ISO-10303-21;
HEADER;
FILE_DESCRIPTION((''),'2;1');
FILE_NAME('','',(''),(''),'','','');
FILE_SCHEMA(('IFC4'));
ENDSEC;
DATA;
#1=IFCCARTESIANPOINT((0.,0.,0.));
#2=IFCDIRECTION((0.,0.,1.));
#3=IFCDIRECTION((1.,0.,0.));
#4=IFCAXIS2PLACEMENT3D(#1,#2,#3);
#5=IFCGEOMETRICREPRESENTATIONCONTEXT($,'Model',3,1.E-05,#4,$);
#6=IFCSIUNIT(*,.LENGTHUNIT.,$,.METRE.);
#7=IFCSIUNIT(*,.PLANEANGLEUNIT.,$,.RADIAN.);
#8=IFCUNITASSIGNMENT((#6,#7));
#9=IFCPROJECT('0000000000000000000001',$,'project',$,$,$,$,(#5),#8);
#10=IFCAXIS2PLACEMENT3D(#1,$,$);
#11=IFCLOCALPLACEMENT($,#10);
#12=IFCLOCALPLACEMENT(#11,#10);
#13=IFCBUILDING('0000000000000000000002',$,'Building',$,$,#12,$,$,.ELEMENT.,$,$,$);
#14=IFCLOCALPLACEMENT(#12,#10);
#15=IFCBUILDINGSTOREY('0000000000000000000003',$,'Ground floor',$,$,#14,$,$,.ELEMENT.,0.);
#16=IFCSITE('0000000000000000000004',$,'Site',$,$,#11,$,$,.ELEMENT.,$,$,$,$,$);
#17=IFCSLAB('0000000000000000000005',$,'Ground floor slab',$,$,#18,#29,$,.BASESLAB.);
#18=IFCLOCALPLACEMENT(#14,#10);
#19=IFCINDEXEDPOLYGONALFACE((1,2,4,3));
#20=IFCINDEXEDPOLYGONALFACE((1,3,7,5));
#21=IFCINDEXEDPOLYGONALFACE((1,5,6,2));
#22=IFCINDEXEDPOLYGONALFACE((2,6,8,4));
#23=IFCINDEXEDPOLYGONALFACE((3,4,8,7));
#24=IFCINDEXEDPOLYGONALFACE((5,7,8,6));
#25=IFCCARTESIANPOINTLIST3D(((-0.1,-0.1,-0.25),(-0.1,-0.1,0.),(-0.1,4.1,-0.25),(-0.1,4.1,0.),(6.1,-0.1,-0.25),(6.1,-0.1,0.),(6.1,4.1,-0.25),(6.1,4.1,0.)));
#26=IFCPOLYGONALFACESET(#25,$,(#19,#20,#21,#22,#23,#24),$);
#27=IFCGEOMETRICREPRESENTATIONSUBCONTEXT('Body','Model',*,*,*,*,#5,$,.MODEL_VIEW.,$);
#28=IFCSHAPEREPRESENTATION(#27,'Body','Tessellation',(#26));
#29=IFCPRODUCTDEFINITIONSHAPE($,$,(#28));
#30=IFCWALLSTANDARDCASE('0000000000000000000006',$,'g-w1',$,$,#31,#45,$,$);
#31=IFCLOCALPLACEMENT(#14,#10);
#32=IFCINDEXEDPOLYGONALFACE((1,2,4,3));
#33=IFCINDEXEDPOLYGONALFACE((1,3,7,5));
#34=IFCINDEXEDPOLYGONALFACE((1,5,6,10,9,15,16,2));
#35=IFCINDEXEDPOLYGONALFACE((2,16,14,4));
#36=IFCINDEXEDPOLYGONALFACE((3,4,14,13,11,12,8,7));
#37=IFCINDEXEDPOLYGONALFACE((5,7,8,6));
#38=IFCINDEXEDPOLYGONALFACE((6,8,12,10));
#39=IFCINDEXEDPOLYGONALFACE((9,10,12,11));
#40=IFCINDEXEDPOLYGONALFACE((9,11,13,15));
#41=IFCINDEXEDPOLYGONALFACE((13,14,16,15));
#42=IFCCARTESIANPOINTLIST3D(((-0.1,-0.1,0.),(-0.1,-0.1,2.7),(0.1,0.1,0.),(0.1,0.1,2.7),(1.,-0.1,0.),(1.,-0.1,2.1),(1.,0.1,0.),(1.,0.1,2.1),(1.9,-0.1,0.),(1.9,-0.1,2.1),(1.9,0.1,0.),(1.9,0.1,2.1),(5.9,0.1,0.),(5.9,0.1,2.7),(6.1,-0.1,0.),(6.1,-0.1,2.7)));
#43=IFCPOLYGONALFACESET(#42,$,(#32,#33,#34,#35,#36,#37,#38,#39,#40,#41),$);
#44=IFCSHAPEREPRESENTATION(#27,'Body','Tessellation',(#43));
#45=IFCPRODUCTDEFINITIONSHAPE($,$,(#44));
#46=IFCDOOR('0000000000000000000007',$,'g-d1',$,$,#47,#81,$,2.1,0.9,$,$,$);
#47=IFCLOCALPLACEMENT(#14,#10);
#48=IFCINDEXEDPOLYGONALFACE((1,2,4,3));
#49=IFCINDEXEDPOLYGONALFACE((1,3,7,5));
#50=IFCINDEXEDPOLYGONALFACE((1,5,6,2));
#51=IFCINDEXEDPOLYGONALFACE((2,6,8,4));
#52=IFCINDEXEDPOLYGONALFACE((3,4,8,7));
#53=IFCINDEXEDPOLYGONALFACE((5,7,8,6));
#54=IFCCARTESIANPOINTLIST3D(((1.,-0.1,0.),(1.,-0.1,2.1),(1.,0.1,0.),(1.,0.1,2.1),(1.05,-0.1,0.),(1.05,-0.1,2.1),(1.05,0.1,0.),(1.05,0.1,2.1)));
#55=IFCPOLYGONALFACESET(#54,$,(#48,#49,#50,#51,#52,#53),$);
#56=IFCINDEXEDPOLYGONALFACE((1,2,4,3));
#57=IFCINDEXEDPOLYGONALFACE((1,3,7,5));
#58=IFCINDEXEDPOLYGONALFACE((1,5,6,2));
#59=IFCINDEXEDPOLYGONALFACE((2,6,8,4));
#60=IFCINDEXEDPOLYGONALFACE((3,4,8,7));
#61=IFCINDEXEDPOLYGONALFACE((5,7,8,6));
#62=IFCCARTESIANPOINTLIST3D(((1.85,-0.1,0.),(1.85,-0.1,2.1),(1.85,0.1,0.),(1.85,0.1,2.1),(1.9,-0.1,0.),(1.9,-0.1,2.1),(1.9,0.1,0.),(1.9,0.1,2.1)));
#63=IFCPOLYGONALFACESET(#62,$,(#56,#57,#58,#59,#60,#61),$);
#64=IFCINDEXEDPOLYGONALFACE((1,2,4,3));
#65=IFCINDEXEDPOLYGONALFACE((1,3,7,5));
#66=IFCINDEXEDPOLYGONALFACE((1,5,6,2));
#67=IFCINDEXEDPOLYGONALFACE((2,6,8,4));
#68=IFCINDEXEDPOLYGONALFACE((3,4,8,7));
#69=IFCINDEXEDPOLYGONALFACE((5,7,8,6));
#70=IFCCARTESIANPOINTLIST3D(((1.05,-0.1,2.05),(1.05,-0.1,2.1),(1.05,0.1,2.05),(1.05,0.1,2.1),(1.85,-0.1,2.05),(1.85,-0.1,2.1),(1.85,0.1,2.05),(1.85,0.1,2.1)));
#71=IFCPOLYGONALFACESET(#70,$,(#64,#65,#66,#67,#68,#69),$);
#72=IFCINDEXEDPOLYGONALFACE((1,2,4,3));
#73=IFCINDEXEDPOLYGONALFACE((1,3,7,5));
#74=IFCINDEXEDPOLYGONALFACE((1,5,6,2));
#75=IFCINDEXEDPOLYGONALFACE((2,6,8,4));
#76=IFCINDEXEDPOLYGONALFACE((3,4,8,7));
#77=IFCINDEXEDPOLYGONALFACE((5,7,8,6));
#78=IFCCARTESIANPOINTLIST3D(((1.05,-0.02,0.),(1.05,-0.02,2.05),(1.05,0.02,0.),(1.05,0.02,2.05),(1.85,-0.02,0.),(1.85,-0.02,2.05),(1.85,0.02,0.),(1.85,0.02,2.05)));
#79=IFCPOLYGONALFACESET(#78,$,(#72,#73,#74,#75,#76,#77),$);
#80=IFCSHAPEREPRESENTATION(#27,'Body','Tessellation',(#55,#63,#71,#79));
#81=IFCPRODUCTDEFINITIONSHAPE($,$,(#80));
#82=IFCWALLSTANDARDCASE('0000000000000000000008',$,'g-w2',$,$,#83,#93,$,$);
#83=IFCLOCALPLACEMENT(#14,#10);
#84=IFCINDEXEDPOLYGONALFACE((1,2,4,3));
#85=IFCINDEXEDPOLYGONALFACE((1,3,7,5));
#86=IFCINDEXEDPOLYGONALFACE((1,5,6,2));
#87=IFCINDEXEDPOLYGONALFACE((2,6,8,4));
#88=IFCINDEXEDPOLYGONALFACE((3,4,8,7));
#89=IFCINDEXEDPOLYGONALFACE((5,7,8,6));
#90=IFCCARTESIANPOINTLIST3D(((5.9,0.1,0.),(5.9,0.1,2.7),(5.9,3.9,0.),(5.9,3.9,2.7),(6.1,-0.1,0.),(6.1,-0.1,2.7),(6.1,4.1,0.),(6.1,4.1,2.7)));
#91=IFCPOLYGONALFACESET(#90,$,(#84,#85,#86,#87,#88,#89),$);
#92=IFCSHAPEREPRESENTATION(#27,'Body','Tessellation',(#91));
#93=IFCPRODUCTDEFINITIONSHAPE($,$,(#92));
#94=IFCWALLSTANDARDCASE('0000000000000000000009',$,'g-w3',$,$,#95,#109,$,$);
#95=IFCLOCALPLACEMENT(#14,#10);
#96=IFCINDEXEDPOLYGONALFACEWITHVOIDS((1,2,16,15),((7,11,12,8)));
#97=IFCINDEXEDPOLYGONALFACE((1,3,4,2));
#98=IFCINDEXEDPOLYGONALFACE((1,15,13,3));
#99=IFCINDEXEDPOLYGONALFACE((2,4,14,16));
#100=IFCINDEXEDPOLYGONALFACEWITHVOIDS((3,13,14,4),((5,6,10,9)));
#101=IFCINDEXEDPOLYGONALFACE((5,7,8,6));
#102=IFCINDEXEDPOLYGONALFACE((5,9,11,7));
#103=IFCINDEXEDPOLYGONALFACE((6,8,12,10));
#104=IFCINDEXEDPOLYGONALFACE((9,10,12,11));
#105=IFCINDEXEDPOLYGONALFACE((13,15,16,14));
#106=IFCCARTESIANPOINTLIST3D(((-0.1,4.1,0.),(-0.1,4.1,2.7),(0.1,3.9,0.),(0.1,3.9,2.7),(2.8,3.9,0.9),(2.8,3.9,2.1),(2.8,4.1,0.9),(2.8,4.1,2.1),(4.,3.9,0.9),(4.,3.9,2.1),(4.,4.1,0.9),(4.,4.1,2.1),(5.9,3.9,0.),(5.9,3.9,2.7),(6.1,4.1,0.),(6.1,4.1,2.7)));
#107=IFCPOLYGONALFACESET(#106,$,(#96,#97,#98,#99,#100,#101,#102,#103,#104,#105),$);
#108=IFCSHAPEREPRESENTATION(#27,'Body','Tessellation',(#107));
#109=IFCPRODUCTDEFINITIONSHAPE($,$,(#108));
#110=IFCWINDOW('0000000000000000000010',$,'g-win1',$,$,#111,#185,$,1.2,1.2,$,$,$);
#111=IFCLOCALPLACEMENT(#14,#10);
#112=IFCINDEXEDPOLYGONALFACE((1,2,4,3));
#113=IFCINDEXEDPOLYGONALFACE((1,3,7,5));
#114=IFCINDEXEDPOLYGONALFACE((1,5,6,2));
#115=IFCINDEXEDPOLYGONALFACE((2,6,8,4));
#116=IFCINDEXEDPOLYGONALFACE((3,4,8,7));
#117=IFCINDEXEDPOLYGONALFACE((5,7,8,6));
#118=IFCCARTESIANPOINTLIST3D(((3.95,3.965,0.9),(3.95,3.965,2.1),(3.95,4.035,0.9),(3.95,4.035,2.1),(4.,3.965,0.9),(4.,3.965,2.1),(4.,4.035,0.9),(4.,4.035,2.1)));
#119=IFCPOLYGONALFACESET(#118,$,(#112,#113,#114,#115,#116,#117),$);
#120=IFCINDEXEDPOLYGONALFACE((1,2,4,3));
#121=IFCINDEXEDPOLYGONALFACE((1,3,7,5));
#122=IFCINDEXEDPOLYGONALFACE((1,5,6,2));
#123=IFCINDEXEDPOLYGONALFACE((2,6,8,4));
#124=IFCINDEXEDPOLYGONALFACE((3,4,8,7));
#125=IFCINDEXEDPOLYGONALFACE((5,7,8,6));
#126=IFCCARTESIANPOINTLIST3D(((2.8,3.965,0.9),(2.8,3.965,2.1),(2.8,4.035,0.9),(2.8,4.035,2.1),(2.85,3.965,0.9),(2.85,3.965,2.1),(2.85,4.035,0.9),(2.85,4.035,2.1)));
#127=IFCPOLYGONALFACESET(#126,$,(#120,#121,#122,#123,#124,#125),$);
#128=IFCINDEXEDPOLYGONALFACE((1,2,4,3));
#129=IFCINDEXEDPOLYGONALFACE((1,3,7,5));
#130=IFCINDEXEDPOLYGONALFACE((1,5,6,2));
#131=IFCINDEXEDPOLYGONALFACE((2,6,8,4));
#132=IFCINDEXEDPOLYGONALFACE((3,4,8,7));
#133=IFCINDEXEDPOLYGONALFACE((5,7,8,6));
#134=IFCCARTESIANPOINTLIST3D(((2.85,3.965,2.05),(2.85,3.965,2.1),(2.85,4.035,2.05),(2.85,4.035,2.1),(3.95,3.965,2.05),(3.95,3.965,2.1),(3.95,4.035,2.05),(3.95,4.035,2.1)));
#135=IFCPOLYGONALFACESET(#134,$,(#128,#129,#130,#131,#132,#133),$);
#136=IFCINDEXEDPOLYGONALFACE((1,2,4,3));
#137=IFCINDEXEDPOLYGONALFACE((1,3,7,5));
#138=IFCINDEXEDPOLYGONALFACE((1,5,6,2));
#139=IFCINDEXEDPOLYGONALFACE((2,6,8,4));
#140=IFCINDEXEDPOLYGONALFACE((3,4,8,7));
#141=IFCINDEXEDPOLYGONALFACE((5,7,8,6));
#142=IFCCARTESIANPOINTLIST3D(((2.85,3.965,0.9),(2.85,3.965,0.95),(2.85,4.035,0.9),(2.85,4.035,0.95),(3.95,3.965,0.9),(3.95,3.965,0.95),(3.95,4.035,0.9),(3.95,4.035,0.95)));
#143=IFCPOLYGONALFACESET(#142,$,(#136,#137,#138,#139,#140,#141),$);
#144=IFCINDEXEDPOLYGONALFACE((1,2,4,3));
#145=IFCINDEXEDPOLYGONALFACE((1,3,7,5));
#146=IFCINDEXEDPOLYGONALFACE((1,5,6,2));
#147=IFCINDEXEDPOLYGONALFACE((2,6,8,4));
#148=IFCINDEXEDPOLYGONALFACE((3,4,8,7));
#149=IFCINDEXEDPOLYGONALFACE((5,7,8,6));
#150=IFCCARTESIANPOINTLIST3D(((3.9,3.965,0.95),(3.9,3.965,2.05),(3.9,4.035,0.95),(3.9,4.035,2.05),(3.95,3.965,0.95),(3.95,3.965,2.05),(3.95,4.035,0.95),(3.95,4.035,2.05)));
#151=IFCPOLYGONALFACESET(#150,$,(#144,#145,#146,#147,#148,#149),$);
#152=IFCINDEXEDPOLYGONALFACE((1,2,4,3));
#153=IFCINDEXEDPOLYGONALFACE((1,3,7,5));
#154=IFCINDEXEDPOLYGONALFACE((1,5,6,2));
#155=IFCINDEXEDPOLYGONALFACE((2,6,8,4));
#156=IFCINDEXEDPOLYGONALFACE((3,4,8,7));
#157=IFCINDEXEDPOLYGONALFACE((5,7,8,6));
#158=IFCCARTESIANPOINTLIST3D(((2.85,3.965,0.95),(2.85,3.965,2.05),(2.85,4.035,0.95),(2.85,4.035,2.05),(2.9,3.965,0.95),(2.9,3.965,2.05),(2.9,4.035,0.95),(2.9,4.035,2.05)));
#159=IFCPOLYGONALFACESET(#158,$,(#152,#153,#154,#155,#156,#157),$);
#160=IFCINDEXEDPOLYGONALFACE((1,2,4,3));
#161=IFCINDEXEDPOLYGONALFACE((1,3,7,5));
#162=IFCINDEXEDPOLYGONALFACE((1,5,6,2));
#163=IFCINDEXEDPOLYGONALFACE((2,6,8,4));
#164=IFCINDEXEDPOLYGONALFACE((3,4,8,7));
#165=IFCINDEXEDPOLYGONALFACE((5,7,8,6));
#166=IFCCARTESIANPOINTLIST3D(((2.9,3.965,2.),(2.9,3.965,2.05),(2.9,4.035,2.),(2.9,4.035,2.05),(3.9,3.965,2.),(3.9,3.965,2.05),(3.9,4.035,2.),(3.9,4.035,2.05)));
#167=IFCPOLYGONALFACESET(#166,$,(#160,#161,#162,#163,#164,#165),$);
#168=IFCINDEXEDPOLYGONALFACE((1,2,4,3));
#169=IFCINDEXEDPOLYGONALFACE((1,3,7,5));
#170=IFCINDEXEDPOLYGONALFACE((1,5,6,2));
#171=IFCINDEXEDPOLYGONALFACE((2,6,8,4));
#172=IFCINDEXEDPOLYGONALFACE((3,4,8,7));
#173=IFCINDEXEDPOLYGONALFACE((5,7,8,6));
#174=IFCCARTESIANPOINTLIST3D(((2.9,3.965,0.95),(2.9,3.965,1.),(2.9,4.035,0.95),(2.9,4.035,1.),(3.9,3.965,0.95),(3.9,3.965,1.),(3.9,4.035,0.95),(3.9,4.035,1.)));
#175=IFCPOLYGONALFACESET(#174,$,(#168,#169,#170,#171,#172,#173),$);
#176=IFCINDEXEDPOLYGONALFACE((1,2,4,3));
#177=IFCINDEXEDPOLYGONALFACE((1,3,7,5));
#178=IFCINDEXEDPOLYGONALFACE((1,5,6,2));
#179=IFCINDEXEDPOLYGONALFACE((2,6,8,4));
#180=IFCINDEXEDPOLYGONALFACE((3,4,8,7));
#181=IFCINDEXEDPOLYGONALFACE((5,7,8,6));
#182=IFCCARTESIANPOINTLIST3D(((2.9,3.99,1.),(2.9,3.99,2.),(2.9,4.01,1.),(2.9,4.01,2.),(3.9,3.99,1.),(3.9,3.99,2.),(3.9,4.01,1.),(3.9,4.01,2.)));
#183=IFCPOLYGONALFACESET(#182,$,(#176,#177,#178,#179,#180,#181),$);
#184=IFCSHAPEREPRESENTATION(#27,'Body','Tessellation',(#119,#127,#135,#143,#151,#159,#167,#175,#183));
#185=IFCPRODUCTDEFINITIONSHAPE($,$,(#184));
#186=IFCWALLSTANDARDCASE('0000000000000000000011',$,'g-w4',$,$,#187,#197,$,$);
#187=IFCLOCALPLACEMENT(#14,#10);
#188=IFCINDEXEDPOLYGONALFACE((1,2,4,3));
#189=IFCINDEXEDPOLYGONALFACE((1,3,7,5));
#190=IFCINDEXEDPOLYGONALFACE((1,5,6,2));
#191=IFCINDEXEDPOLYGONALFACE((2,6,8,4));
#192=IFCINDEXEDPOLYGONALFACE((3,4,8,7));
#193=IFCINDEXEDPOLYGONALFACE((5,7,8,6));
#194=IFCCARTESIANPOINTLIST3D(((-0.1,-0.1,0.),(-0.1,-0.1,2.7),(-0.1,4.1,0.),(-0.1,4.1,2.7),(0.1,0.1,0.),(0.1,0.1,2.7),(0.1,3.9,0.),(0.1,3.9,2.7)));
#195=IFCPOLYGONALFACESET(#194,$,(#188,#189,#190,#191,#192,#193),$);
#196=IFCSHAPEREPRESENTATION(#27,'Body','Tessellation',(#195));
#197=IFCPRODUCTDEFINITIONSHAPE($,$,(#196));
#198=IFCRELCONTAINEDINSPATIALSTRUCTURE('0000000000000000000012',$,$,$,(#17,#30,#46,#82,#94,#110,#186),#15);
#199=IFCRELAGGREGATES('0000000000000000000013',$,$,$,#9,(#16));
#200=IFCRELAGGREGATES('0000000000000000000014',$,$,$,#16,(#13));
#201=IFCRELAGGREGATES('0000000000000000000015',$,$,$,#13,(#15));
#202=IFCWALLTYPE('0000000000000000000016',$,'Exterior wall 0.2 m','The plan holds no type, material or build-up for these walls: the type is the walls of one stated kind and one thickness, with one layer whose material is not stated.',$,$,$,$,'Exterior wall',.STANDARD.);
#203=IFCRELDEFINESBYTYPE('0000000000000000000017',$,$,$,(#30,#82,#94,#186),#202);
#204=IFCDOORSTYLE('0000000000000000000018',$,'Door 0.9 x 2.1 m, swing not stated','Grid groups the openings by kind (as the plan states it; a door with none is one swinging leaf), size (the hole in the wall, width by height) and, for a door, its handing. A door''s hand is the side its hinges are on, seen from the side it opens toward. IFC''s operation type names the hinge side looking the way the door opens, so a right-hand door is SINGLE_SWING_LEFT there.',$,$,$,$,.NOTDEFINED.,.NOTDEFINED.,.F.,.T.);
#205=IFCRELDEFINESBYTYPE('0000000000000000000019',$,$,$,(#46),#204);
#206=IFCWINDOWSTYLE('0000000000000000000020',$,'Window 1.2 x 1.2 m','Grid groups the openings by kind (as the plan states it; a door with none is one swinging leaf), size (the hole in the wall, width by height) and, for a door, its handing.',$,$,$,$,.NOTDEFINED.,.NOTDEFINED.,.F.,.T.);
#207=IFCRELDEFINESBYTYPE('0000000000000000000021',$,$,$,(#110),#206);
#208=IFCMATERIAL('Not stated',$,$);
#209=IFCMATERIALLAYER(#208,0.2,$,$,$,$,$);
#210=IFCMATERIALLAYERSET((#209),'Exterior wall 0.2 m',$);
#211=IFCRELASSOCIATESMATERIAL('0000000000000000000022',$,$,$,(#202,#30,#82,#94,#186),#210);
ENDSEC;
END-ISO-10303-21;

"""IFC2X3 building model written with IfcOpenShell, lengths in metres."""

from ifc_helpers import new_model, si_unit, frame, frame_2d, origin, origin_with_axes, place, context, subcontext, project, spatial, polyline, rectangle, outline, extrude, material, layer, layer_set, layer_usage, type_object, element, fill, save


model = new_model("IFC2X3")

# Units and contexts
model_context = context("Model", 3, precision=1e-05, world=origin_with_axes())
body_context = subcontext(model_context, "Body", "Model", "MODEL_VIEW")
ifc_project = project(units=[si_unit("LENGTHUNIT", "METRE"), si_unit("PLANEANGLEUNIT", "RADIAN")], contexts=[model_context])

# Site, building, storey
site_placement = place(None, origin())
site = spatial("IfcSite", under=ifc_project, at=site_placement, Name="Site", CompositionType="ELEMENT")
building_placement = place(site_placement, origin())
building = spatial("IfcBuilding", under=site, at=building_placement, Name="Building", CompositionType="ELEMENT")
storey_placement = place(building_placement, origin())
storey = spatial("IfcBuildingStorey", under=building, at=storey_placement, Name="Ground floor", CompositionType="ELEMENT", Elevation=0.0)

# Slab
slab_placement = place(storey_placement, frame((0.0, 0.0, -0.25)))
element("IfcSlab", 1, at=slab_placement, inside=storey, Name="Ground floor slab", PredefinedType="BASESLAB", context=body_context, shape_type="SweptSolid", body=[
    extrude(outline(polyline([(-0.1, -0.1), (6.1, -0.1), (6.1, 4.1), (-0.1, 4.1), (-0.1, -0.1)])), origin(), (0.0, 0.0, 1.0), 0.25),
])

# Wall, opening, door
ifc_material = material(Name="Not stated")
ifc_layer = layer(ifc_material, 0.2)
ifc_layer_set = layer_set([ifc_layer], Name="Exterior wall 0.2 m")
ifc_layer_usage = layer_usage(ifc_layer_set, "AXIS2", "POSITIVE", -0.1)
wall_type = type_object("IfcWallType", Name="Exterior wall 0.2 m", Description="The plan holds no type, material or build-up for these walls: the type is the walls of one stated kind and one thickness, with one layer whose material is not stated.", ElementType="Exterior wall", PredefinedType="STANDARD", material=ifc_layer_set)
wall_1_placement = place(storey_placement, origin_with_axes())
wall_1 = element("IfcWallStandardCase", 2, at=wall_1_placement, inside=storey, type_object=wall_type, material=ifc_layer_usage, Name="g-w1", context=body_context, shape_type="SweptSolid", body=[
    extrude(outline(polyline([(-0.1, -0.1), (6.1, -0.1), (5.9, 0.1), (0.1, 0.1), (-0.1, -0.1)])), origin(), (0.0, 0.0, 1.0), 2.7),
])
opening_1_placement = place(wall_1_placement, frame((1.0, 0.0, 0.0)))
opening_1 = element("IfcOpeningElement", 3, at=opening_1_placement, cuts=wall_1, context=body_context, shape_type="SweptSolid", body=[
    extrude(rectangle(XDim=0.9, YDim=0.22, at=frame_2d((0.45, 0.0), x_axis=(1.0, 0.0))), origin(), (0.0, 0.0, 1.0), 2.1),
])
door_style = type_object("IfcDoorStyle", Name="Door 0.9 x 2.1 m, swing not stated", Description="Grid groups the openings by kind (as the plan states it; a door with none is one swinging leaf), size (the hole in the wall, width by height) and, for a door, its handing. A door's hand is the side its hinges are on, seen from the side it opens toward. IFC's operation type names the hinge side looking the way the door opens, so a right-hand door is SINGLE_SWING_LEFT there.", ConstructionType="NOTDEFINED", OperationType="NOTDEFINED", ParameterTakesPrecedence=False, Sizeable=True)
door_placement = place(opening_1_placement, origin())
door = element("IfcDoor", 4, at=door_placement, inside=storey, type_object=door_style, Name="g-d1", OverallHeight=2.1, OverallWidth=0.9, context=body_context, shape_type="SweptSolid", body=[
    extrude(rectangle(XDim=0.05, YDim=0.2, at=frame_2d((0.025, 0.0), x_axis=(1.0, 0.0))), origin(), (0.0, 0.0, 1.0), 2.1),
    extrude(rectangle(XDim=0.05, YDim=0.2, at=frame_2d((0.875, 0.0), x_axis=(1.0, 0.0))), origin(), (0.0, 0.0, 1.0), 2.1),
    extrude(rectangle(XDim=0.8, YDim=0.2, at=frame_2d((0.45, 0.0), x_axis=(1.0, 0.0))), frame((0.0, 0.0, 2.05)), (0.0, 0.0, 1.0), 0.05),
    extrude(rectangle(XDim=0.8, YDim=0.04, at=frame_2d((0.45, 0.0), x_axis=(1.0, 0.0))), origin(), (0.0, 0.0, 1.0), 2.05),
])
fill(opening_1, door)

# Wall
wall_2_placement = place(storey_placement, frame((6.0, 0.0, 0.0), z_axis=(0.0, 0.0, 1.0), x_axis=(0.0, 1.0, 0.0)))
element("IfcWallStandardCase", 5, at=wall_2_placement, inside=storey, type_object=wall_type, material=ifc_layer_usage, Name="g-w2", context=body_context, shape_type="SweptSolid", body=[
    extrude(outline(polyline([(-0.1, -0.1), (4.1, -0.1), (3.9, 0.1), (0.1, 0.1), (-0.1, -0.1)])), origin(), (0.0, 0.0, 1.0), 2.7),
])

# Wall, opening, window
wall_3_placement = place(storey_placement, frame((6.0, 4.0, 0.0), z_axis=(0.0, 0.0, 1.0), x_axis=(-1.0, 0.0, 0.0)))
wall_3 = element("IfcWallStandardCase", 6, at=wall_3_placement, inside=storey, type_object=wall_type, material=ifc_layer_usage, Name="g-w3", context=body_context, shape_type="SweptSolid", body=[
    extrude(outline(polyline([(-0.1, -0.1), (6.1, -0.1), (5.9, 0.1), (0.1, 0.1), (-0.1, -0.1)])), origin(), (0.0, 0.0, 1.0), 2.7),
])
opening_2_placement = place(wall_3_placement, frame((2.0, 0.0, 0.9)))
opening_2 = element("IfcOpeningElement", 7, at=opening_2_placement, cuts=wall_3, context=body_context, shape_type="SweptSolid", body=[
    extrude(rectangle(XDim=1.2, YDim=0.22, at=frame_2d((0.6, 0.0), x_axis=(1.0, 0.0))), origin(), (0.0, 0.0, 1.0), 1.2),
])
window_style = type_object("IfcWindowStyle", Name="Window 1.2 x 1.2 m", Description="Grid groups the openings by kind (as the plan states it; a door with none is one swinging leaf), size (the hole in the wall, width by height) and, for a door, its handing.", ConstructionType="NOTDEFINED", OperationType="NOTDEFINED", ParameterTakesPrecedence=False, Sizeable=True)
window_placement = place(opening_2_placement, origin())
window = element("IfcWindow", 8, at=window_placement, inside=storey, type_object=window_style, Name="g-win1", OverallHeight=1.2, OverallWidth=1.2, context=body_context, shape_type="SweptSolid", body=[
    extrude(rectangle(XDim=0.05, YDim=0.07, at=frame_2d((0.025, 0.0), x_axis=(1.0, 0.0))), origin(), (0.0, 0.0, 1.0), 1.2),
    extrude(rectangle(XDim=0.05, YDim=0.07, at=frame_2d((1.175, 0.0), x_axis=(1.0, 0.0))), origin(), (0.0, 0.0, 1.0), 1.2),
    extrude(rectangle(XDim=1.1, YDim=0.07, at=frame_2d((0.6, 0.0), x_axis=(1.0, 0.0))), frame((0.0, 0.0, 1.15)), (0.0, 0.0, 1.0), 0.05),
    extrude(rectangle(XDim=1.1, YDim=0.07, at=frame_2d((0.6, 0.0), x_axis=(1.0, 0.0))), origin(), (0.0, 0.0, 1.0), 0.05),
    extrude(rectangle(XDim=0.05, YDim=0.07, at=frame_2d((0.075, 0.0), x_axis=(1.0, 0.0))), frame((0.0, 0.0, 0.05)), (0.0, 0.0, 1.0), 1.1),
    extrude(rectangle(XDim=0.05, YDim=0.07, at=frame_2d((1.125, 0.0), x_axis=(1.0, 0.0))), frame((0.0, 0.0, 0.05)), (0.0, 0.0, 1.0), 1.1),
    extrude(rectangle(XDim=1.0, YDim=0.07, at=frame_2d((0.6, 0.0), x_axis=(1.0, 0.0))), frame((0.0, 0.0, 1.1)), (0.0, 0.0, 1.0), 0.05),
    extrude(rectangle(XDim=1.0, YDim=0.07, at=frame_2d((0.6, 0.0), x_axis=(1.0, 0.0))), frame((0.0, 0.0, 0.05)), (0.0, 0.0, 1.0), 0.05),
    extrude(rectangle(XDim=1.0, YDim=0.02, at=frame_2d((0.6, 0.0), x_axis=(1.0, 0.0))), frame((0.0, 0.0, 0.1)), (0.0, 0.0, 1.0), 1.0),
])
fill(opening_2, window)

# Wall
wall_4_placement = place(storey_placement, frame((0.0, 4.0, 0.0), z_axis=(0.0, 0.0, 1.0), x_axis=(0.0, -1.0, 0.0)))
element("IfcWallStandardCase", 9, at=wall_4_placement, inside=storey, type_object=wall_type, material=ifc_layer_usage, Name="g-w4", context=body_context, shape_type="SweptSolid", body=[
    extrude(outline(polyline([(-0.1, -0.1), (4.1, -0.1), (3.9, 0.1), (0.1, 0.1), (-0.1, -0.1)])), origin(), (0.0, 0.0, 1.0), 2.7),
])

save(model, "model.ifc")
